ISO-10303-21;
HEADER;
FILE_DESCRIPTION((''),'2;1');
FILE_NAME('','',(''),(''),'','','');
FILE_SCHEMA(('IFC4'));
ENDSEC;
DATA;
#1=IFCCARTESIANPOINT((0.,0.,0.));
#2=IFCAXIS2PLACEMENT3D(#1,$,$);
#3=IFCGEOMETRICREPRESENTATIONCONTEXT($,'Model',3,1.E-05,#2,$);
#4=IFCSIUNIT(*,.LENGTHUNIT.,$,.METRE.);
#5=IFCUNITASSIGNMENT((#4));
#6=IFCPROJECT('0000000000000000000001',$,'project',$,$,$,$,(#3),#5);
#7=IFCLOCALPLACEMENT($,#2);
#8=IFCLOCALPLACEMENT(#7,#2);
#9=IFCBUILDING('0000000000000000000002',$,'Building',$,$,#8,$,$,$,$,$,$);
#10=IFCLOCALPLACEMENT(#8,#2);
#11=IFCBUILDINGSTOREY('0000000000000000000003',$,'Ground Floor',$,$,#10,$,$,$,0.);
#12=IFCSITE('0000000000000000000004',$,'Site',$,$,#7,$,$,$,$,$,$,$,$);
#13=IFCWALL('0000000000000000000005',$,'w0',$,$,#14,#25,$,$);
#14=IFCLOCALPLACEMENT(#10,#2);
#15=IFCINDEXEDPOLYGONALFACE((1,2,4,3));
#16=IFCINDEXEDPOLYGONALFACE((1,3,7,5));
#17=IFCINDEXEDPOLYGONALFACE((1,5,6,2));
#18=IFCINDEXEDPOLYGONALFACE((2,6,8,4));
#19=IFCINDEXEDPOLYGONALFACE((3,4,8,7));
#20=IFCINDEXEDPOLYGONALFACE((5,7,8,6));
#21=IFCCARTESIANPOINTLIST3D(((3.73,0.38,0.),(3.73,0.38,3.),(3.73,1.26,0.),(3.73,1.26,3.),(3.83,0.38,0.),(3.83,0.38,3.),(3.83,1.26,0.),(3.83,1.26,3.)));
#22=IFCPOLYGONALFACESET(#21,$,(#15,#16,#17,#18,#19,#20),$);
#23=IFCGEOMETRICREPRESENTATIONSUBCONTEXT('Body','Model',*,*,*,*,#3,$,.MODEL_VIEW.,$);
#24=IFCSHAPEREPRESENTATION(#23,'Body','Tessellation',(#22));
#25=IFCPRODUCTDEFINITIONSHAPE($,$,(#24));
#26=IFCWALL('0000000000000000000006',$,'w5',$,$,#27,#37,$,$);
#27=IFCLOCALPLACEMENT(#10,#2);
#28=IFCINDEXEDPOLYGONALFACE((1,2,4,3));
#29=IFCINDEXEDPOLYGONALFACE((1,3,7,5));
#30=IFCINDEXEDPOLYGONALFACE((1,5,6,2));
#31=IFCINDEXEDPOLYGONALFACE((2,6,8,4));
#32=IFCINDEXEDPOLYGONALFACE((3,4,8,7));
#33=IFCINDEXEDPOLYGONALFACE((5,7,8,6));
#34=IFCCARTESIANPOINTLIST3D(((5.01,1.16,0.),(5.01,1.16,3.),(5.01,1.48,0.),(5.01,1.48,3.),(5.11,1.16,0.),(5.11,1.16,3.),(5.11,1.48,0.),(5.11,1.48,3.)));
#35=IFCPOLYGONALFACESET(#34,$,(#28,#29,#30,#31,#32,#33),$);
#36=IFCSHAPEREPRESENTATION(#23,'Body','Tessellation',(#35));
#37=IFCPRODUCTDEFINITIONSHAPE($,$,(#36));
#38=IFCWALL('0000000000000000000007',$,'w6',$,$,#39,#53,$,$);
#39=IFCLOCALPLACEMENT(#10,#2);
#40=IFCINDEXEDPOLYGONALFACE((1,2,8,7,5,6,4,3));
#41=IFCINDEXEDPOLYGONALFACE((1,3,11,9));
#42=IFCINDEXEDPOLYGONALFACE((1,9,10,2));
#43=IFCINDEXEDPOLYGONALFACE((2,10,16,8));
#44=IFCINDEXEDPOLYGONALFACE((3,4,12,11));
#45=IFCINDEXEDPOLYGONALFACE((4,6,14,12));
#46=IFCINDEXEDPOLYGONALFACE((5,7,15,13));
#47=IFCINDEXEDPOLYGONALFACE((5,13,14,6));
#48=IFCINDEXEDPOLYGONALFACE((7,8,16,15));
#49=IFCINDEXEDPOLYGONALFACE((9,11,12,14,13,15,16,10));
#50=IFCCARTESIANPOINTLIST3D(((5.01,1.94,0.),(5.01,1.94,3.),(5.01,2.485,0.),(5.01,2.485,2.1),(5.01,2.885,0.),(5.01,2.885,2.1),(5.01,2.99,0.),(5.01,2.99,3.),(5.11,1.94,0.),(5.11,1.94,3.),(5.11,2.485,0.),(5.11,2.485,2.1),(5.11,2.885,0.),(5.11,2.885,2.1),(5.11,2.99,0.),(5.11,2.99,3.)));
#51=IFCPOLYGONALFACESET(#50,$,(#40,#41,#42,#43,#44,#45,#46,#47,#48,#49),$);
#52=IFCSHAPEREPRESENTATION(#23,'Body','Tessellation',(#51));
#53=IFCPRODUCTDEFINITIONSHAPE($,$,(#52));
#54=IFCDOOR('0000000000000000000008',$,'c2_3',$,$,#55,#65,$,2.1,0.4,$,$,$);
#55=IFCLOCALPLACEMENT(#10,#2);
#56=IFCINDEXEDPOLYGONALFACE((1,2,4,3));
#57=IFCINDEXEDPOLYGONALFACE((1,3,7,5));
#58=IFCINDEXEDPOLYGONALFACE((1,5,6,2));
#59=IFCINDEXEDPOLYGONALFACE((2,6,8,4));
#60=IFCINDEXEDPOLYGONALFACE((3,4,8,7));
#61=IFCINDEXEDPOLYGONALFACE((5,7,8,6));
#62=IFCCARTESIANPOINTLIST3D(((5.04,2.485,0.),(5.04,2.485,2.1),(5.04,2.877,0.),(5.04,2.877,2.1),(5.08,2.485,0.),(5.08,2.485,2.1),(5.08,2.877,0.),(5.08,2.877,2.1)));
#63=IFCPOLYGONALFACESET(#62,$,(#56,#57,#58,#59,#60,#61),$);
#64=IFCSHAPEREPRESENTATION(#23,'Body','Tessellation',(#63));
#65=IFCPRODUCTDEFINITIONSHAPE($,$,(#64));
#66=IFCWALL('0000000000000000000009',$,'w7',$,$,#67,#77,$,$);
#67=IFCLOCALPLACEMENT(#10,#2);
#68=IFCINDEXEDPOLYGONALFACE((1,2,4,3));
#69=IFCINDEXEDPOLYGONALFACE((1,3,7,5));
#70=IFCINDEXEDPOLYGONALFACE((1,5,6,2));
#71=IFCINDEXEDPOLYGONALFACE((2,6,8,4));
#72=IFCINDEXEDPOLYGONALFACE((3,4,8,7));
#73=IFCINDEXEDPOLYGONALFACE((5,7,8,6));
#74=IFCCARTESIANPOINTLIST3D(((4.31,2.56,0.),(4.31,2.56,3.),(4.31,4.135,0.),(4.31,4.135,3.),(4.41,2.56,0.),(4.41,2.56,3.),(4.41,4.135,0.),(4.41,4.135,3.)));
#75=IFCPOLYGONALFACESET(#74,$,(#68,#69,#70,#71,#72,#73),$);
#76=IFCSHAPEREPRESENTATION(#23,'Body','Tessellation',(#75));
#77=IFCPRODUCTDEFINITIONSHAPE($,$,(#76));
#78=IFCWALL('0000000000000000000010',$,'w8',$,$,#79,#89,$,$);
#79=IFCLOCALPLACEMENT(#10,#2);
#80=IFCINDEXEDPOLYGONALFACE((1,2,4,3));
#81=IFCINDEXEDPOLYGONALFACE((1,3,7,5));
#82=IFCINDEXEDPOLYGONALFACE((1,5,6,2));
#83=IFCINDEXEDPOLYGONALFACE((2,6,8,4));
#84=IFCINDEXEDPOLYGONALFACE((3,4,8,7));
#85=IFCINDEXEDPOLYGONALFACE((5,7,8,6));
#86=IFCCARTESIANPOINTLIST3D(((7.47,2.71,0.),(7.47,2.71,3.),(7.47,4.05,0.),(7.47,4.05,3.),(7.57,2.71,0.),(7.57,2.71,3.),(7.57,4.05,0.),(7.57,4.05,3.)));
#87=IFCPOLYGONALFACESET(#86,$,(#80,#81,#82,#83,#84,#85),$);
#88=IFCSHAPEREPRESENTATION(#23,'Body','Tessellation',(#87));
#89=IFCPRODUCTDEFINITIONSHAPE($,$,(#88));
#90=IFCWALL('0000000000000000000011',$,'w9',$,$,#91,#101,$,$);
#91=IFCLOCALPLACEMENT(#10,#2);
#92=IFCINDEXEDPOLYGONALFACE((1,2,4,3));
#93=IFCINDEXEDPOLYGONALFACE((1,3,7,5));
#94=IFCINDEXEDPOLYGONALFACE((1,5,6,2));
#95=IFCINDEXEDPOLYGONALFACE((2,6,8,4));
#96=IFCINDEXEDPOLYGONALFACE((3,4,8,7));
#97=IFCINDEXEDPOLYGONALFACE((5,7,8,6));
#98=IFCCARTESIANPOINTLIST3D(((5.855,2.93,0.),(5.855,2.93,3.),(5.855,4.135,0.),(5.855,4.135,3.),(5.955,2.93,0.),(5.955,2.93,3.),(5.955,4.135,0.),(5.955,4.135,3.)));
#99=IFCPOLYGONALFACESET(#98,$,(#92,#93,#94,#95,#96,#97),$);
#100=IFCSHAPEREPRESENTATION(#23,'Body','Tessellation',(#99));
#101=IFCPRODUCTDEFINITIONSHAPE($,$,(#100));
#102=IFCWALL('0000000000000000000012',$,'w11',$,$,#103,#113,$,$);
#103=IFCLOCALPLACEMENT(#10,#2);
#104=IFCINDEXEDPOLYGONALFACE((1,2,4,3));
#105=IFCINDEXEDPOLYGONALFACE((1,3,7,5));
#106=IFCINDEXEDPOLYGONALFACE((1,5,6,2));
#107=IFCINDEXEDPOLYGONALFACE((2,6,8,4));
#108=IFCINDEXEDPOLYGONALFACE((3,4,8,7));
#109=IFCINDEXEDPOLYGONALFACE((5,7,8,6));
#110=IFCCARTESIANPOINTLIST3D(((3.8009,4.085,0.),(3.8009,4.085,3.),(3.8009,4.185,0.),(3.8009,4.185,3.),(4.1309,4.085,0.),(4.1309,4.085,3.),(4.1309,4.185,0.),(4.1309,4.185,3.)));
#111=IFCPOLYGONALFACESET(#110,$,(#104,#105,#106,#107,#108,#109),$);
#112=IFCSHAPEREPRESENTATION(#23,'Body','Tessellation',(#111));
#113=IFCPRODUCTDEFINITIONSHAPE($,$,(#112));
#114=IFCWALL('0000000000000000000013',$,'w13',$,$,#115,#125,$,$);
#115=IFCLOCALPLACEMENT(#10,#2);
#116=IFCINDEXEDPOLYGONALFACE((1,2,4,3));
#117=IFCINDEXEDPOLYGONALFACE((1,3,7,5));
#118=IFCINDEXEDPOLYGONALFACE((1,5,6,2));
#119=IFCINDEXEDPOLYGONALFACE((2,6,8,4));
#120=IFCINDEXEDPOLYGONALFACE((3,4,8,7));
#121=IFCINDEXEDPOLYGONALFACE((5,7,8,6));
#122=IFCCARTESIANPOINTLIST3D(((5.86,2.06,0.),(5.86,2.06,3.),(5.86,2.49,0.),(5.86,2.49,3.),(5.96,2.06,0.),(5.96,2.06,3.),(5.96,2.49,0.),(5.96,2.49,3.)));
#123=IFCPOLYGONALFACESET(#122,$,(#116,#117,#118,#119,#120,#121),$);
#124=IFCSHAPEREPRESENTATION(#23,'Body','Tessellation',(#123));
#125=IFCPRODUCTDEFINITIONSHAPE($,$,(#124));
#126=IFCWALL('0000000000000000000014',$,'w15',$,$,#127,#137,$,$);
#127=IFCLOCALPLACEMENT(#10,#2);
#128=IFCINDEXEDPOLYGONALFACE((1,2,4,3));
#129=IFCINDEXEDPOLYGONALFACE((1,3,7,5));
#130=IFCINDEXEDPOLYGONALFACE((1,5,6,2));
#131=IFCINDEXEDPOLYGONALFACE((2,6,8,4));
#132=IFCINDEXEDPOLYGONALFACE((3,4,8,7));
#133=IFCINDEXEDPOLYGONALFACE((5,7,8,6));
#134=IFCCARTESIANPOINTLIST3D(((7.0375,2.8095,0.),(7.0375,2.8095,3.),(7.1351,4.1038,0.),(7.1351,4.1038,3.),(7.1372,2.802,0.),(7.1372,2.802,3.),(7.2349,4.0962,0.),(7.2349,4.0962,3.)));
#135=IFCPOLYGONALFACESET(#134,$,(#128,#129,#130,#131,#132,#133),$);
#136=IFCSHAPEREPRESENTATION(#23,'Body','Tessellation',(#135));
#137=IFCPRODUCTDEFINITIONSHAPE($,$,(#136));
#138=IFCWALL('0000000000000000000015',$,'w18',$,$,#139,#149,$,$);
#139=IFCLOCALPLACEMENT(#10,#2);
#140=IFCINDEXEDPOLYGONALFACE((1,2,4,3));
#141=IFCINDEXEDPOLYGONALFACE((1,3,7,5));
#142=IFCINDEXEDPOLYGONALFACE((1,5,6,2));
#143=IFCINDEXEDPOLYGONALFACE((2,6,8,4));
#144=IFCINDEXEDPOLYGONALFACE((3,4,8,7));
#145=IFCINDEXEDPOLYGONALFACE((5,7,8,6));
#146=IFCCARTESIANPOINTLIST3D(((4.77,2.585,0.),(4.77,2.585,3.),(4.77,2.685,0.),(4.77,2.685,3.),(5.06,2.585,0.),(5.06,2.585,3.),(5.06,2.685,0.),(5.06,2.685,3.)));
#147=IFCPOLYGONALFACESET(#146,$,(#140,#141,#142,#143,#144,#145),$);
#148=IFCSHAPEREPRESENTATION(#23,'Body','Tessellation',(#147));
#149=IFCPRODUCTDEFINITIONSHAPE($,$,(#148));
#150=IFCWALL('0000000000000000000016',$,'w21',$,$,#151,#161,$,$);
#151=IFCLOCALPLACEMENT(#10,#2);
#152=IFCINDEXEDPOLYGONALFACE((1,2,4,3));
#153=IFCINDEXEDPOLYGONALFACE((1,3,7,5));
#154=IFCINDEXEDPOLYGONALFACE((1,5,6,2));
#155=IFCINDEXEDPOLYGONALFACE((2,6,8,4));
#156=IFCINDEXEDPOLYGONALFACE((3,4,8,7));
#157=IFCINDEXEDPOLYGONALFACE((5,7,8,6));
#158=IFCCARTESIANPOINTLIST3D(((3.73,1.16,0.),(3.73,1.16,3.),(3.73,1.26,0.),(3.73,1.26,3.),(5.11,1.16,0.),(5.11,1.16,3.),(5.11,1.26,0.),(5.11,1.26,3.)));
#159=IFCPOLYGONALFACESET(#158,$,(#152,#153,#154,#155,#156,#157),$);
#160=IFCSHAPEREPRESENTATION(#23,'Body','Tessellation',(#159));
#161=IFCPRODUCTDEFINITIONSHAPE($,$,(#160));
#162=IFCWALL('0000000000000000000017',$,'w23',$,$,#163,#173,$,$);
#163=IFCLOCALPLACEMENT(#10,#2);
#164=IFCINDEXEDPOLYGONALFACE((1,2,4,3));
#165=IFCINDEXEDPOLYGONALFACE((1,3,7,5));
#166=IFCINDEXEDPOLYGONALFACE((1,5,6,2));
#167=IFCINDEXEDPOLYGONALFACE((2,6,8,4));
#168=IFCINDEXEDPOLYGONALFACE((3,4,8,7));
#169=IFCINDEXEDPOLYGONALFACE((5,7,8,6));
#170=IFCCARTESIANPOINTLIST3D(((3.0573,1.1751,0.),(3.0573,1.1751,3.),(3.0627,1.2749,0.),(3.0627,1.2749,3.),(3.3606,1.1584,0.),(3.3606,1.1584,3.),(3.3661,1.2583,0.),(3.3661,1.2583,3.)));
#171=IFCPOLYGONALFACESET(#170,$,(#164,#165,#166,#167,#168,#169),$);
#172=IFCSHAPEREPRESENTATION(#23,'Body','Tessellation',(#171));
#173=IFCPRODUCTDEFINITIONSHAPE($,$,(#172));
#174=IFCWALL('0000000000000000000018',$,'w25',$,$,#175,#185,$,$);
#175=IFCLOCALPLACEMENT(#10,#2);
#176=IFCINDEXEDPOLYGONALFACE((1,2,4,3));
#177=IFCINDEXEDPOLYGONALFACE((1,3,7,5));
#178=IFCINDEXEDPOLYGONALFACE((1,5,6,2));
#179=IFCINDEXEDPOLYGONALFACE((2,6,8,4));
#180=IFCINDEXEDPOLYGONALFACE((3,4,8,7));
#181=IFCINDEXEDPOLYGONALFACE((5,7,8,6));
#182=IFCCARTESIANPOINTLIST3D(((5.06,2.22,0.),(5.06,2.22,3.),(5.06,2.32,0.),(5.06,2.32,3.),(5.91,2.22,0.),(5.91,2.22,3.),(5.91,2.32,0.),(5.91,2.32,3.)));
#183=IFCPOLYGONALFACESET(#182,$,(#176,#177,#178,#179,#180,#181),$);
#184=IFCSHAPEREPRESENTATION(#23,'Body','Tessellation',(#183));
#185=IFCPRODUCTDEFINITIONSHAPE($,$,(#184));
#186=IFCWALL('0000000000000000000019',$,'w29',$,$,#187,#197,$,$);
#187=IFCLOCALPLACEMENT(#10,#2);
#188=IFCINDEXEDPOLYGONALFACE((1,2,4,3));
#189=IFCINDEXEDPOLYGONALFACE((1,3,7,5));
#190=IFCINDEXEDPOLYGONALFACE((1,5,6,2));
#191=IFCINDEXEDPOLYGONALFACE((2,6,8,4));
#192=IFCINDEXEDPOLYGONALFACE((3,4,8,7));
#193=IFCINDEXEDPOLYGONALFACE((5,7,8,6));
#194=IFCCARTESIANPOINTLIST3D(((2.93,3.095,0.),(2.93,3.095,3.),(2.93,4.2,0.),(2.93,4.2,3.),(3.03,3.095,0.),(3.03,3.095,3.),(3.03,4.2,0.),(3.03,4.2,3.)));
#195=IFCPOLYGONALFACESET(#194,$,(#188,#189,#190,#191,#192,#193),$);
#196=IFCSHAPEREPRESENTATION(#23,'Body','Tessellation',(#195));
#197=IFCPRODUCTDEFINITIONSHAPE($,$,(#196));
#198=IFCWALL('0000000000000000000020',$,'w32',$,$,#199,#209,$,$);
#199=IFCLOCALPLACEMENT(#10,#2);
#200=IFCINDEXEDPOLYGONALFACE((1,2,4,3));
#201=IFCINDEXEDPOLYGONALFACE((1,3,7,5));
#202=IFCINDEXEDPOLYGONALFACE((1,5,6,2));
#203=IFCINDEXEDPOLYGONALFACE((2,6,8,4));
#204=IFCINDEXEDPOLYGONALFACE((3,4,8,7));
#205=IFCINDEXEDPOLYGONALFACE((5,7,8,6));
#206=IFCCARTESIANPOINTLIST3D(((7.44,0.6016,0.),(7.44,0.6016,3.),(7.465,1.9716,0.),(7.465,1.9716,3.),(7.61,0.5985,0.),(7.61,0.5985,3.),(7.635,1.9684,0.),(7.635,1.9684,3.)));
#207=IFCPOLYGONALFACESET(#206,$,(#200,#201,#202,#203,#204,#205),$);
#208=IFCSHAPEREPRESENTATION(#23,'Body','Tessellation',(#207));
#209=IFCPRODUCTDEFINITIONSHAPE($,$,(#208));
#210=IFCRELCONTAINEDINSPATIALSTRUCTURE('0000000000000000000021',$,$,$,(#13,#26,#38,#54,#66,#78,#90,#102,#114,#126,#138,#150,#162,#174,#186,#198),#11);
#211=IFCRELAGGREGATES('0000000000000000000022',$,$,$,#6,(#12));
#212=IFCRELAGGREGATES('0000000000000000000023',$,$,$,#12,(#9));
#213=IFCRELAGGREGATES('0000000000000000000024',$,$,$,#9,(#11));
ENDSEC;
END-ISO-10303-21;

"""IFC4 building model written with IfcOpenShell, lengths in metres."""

from ifc_helpers import new_model, si_unit, frame, origin, place, context, subcontext, project, spatial, polyline, outline, extrude, element, fill, save


model = new_model("IFC4")

# Units and contexts
model_context = context("Model", 3, precision=1e-05, world=origin())
body_context = subcontext(model_context, "Body", "Model", "MODEL_VIEW")
ifc_project = project(units=[si_unit("LENGTHUNIT", "METRE")], contexts=[model_context])

# Site, building, storey
site_placement = place(None, origin())
site = spatial("IfcSite", under=ifc_project, at=site_placement, Name="Site")
building_placement = place(site_placement, origin())
building = spatial("IfcBuilding", under=site, at=building_placement, Name="Building")
storey_placement = place(building_placement, origin())
storey = spatial("IfcBuildingStorey", under=building, at=storey_placement, Name="Ground Floor", Elevation=0.0)

# Wall
wall_1_placement = place(storey_placement, frame((3.78, 0.38, 0.0), x_axis=(0.0, 1.0, 0.0)))
element("IfcWall", 1, at=wall_1_placement, inside=storey, Name="w0", context=body_context, shape_type="SweptSolid", body=[
    extrude(outline(polyline([(0.0, -0.05), (0.88, -0.05), (0.88, 0.05), (0.0, 0.05), (0.0, -0.05)])), origin(), (0.0, 0.0, 1.0), 3.0),
])

# Wall
wall_2_placement = place(storey_placement, frame((5.06, 1.21, 0.0), x_axis=(0.0, 1.0, 0.0)))
element("IfcWall", 2, at=wall_2_placement, inside=storey, Name="w5", context=body_context, shape_type="SweptSolid", body=[
    extrude(outline(polyline([(-0.05, -0.05), (0.27, -0.05), (0.27, 0.05), (-0.05, 0.05), (-0.05, -0.05)])), origin(), (0.0, 0.0, 1.0), 3.0),
])

# Wall, opening, door
wall_3_placement = place(storey_placement, frame((5.06, 1.94, 0.0), x_axis=(0.0, 1.0, 0.0)))
wall_3 = element("IfcWall", 3, at=wall_3_placement, inside=storey, Name="w6", context=body_context, shape_type="SweptSolid", body=[
    extrude(outline(polyline([(0.0, -0.05), (1.05, -0.05), (1.05, 0.05), (0.0, 0.05), (0.0, -0.05)])), origin(), (0.0, 0.0, 1.0), 3.0),
])
opening_1_placement = place(wall_3_placement, frame((0.545, 0.0, 0.0)))
opening_1 = element("IfcOpeningElement", 4, at=opening_1_placement, cuts=wall_3, context=body_context, shape_type="SweptSolid", body=[
    extrude(outline(polyline([(0.0, -0.0525), (0.4, -0.0525), (0.4, 0.0525), (0.0, 0.0525), (0.0, -0.0525)])), origin(), (0.0, 0.0, 1.0), 2.1),
])
door_placement = place(wall_3_placement, frame((0.545, 0.0, 0.0)))
door = element("IfcDoor", 5, at=door_placement, inside=storey, Name="c2_3", OverallHeight=2.1, OverallWidth=0.4, context=body_context, shape_type="SweptSolid", body=[
    extrude(outline(polyline([(0.0, -0.02), (0.392, -0.02), (0.392, 0.02), (0.0, 0.02), (0.0, -0.02)])), origin(), (0.0, 0.0, 1.0), 2.1),
])
fill(opening_1, door)

# Walls
wall_4_placement = place(storey_placement, frame((4.36, 2.56, 0.0), x_axis=(0.0, 1.0, 0.0)))
element("IfcWall", 6, at=wall_4_placement, inside=storey, Name="w7", context=body_context, shape_type="SweptSolid", body=[
    extrude(outline(polyline([(0.0, -0.05), (1.575, -0.05), (1.575, 0.05), (0.0, 0.05), (0.0, -0.05)])), origin(), (0.0, 0.0, 1.0), 3.0),
])
wall_5_placement = place(storey_placement, frame((7.52, 2.71, 0.0), x_axis=(0.0, 1.0, 0.0)))
element("IfcWall", 7, at=wall_5_placement, inside=storey, Name="w8", context=body_context, shape_type="SweptSolid", body=[
    extrude(outline(polyline([(0.0, -0.05), (1.34, -0.05), (1.34, 0.05), (0.0, 0.05), (0.0, -0.05)])), origin(), (0.0, 0.0, 1.0), 3.0),
])
wall_6_placement = place(storey_placement, frame((5.905, 2.93, 0.0), x_axis=(0.0, 1.0, 0.0)))
element("IfcWall", 8, at=wall_6_placement, inside=storey, Name="w9", context=body_context, shape_type="SweptSolid", body=[
    extrude(outline(polyline([(0.0, -0.05), (1.205, -0.05), (1.205, 0.05), (0.0, 0.05), (0.0, -0.05)])), origin(), (0.0, 0.0, 1.0), 3.0),
])
wall_7_placement = place(storey_placement, frame((3.8009, 4.135, 0.0), x_axis=(1.0, 0.0, 0.0)))
element("IfcWall", 9, at=wall_7_placement, inside=storey, Name="w11", context=body_context, shape_type="SweptSolid", body=[
    extrude(outline(polyline([(0.0, -0.05), (0.33, -0.05), (0.33, 0.05), (0.0, 0.05), (0.0, -0.05)])), origin(), (0.0, 0.0, 1.0), 3.0),
])
wall_8_placement = place(storey_placement, frame((5.91, 2.06, 0.0), x_axis=(0.0, 1.0, 0.0)))
element("IfcWall", 10, at=wall_8_placement, inside=storey, Name="w13", context=body_context, shape_type="SweptSolid", body=[
    extrude(outline(polyline([(0.0, -0.05), (0.43, -0.05), (0.43, 0.05), (0.0, 0.05), (0.0, -0.05)])), origin(), (0.0, 0.0, 1.0), 3.0),
])
wall_9_placement = place(storey_placement, frame((7.0873, 2.8057, 0.0), x_axis=(0.07525, 0.997165, 0.0)))
element("IfcWall", 11, at=wall_9_placement, inside=storey, Name="w15", context=body_context, shape_type="SweptSolid", body=[
    extrude(outline(polyline([(0.0, -0.05), (1.2979, -0.05), (1.2979, 0.05), (0.0, 0.05), (0.0, -0.05)])), origin(), (0.0, 0.0, 1.0), 3.0),
])
wall_10_placement = place(storey_placement, frame((4.77, 2.635, 0.0), x_axis=(1.0, 0.0, 0.0)))
element("IfcWall", 12, at=wall_10_placement, inside=storey, Name="w18", context=body_context, shape_type="SweptSolid", body=[
    extrude(outline(polyline([(0.0, -0.05), (0.29, -0.05), (0.29, 0.05), (0.0, 0.05), (0.0, -0.05)])), origin(), (0.0, 0.0, 1.0), 3.0),
])
wall_11_placement = place(storey_placement, frame((3.78, 1.21, 0.0), x_axis=(1.0, 0.0, 0.0)))
element("IfcWall", 13, at=wall_11_placement, inside=storey, Name="w21", context=body_context, shape_type="SweptSolid", body=[
    extrude(outline(polyline([(-0.05, -0.05), (1.33, -0.05), (1.33, 0.05), (-0.05, 0.05), (-0.05, -0.05)])), origin(), (0.0, 0.0, 1.0), 3.0),
])
wall_12_placement = place(storey_placement, frame((3.06, 1.225, 0.0), x_axis=(0.998494, -0.054861, 0.0)))
element("IfcWall", 14, at=wall_12_placement, inside=storey, Name="w23", context=body_context, shape_type="SweptSolid", body=[
    extrude(outline(polyline([(0.0, -0.05), (0.3038, -0.05), (0.3038, 0.05), (0.0, 0.05), (0.0, -0.05)])), origin(), (0.0, 0.0, 1.0), 3.0),
])
wall_13_placement = place(storey_placement, frame((5.06, 2.27, 0.0), x_axis=(1.0, 0.0, 0.0)))
element("IfcWall", 15, at=wall_13_placement, inside=storey, Name="w25", context=body_context, shape_type="SweptSolid", body=[
    extrude(outline(polyline([(0.0, -0.05), (0.85, -0.05), (0.85, 0.05), (0.0, 0.05), (0.0, -0.05)])), origin(), (0.0, 0.0, 1.0), 3.0),
])
wall_14_placement = place(storey_placement, frame((2.98, 3.145, 0.0), x_axis=(0.0, 1.0, 0.0)))
element("IfcWall", 16, at=wall_14_placement, inside=storey, Name="w29", context=body_context, shape_type="SweptSolid", body=[
    extrude(outline(polyline([(-0.05, -0.05), (1.055, -0.05), (1.055, 0.05), (-0.05, 0.05), (-0.05, -0.05)])), origin(), (0.0, 0.0, 1.0), 3.0),
])
wall_15_placement = place(storey_placement, frame((7.525, 0.6, 0.0), x_axis=(0.018244, 0.999834, 0.0)))
element("IfcWall", 17, at=wall_15_placement, inside=storey, Name="w32", context=body_context, shape_type="SweptSolid", body=[
    extrude(outline(polyline([(0.0, -0.085), (1.3702, -0.085), (1.3702, 0.085), (0.0, 0.085), (0.0, -0.085)])), origin(), (0.0, 0.0, 1.0), 3.0),
])

save(model, "model.ifc")
